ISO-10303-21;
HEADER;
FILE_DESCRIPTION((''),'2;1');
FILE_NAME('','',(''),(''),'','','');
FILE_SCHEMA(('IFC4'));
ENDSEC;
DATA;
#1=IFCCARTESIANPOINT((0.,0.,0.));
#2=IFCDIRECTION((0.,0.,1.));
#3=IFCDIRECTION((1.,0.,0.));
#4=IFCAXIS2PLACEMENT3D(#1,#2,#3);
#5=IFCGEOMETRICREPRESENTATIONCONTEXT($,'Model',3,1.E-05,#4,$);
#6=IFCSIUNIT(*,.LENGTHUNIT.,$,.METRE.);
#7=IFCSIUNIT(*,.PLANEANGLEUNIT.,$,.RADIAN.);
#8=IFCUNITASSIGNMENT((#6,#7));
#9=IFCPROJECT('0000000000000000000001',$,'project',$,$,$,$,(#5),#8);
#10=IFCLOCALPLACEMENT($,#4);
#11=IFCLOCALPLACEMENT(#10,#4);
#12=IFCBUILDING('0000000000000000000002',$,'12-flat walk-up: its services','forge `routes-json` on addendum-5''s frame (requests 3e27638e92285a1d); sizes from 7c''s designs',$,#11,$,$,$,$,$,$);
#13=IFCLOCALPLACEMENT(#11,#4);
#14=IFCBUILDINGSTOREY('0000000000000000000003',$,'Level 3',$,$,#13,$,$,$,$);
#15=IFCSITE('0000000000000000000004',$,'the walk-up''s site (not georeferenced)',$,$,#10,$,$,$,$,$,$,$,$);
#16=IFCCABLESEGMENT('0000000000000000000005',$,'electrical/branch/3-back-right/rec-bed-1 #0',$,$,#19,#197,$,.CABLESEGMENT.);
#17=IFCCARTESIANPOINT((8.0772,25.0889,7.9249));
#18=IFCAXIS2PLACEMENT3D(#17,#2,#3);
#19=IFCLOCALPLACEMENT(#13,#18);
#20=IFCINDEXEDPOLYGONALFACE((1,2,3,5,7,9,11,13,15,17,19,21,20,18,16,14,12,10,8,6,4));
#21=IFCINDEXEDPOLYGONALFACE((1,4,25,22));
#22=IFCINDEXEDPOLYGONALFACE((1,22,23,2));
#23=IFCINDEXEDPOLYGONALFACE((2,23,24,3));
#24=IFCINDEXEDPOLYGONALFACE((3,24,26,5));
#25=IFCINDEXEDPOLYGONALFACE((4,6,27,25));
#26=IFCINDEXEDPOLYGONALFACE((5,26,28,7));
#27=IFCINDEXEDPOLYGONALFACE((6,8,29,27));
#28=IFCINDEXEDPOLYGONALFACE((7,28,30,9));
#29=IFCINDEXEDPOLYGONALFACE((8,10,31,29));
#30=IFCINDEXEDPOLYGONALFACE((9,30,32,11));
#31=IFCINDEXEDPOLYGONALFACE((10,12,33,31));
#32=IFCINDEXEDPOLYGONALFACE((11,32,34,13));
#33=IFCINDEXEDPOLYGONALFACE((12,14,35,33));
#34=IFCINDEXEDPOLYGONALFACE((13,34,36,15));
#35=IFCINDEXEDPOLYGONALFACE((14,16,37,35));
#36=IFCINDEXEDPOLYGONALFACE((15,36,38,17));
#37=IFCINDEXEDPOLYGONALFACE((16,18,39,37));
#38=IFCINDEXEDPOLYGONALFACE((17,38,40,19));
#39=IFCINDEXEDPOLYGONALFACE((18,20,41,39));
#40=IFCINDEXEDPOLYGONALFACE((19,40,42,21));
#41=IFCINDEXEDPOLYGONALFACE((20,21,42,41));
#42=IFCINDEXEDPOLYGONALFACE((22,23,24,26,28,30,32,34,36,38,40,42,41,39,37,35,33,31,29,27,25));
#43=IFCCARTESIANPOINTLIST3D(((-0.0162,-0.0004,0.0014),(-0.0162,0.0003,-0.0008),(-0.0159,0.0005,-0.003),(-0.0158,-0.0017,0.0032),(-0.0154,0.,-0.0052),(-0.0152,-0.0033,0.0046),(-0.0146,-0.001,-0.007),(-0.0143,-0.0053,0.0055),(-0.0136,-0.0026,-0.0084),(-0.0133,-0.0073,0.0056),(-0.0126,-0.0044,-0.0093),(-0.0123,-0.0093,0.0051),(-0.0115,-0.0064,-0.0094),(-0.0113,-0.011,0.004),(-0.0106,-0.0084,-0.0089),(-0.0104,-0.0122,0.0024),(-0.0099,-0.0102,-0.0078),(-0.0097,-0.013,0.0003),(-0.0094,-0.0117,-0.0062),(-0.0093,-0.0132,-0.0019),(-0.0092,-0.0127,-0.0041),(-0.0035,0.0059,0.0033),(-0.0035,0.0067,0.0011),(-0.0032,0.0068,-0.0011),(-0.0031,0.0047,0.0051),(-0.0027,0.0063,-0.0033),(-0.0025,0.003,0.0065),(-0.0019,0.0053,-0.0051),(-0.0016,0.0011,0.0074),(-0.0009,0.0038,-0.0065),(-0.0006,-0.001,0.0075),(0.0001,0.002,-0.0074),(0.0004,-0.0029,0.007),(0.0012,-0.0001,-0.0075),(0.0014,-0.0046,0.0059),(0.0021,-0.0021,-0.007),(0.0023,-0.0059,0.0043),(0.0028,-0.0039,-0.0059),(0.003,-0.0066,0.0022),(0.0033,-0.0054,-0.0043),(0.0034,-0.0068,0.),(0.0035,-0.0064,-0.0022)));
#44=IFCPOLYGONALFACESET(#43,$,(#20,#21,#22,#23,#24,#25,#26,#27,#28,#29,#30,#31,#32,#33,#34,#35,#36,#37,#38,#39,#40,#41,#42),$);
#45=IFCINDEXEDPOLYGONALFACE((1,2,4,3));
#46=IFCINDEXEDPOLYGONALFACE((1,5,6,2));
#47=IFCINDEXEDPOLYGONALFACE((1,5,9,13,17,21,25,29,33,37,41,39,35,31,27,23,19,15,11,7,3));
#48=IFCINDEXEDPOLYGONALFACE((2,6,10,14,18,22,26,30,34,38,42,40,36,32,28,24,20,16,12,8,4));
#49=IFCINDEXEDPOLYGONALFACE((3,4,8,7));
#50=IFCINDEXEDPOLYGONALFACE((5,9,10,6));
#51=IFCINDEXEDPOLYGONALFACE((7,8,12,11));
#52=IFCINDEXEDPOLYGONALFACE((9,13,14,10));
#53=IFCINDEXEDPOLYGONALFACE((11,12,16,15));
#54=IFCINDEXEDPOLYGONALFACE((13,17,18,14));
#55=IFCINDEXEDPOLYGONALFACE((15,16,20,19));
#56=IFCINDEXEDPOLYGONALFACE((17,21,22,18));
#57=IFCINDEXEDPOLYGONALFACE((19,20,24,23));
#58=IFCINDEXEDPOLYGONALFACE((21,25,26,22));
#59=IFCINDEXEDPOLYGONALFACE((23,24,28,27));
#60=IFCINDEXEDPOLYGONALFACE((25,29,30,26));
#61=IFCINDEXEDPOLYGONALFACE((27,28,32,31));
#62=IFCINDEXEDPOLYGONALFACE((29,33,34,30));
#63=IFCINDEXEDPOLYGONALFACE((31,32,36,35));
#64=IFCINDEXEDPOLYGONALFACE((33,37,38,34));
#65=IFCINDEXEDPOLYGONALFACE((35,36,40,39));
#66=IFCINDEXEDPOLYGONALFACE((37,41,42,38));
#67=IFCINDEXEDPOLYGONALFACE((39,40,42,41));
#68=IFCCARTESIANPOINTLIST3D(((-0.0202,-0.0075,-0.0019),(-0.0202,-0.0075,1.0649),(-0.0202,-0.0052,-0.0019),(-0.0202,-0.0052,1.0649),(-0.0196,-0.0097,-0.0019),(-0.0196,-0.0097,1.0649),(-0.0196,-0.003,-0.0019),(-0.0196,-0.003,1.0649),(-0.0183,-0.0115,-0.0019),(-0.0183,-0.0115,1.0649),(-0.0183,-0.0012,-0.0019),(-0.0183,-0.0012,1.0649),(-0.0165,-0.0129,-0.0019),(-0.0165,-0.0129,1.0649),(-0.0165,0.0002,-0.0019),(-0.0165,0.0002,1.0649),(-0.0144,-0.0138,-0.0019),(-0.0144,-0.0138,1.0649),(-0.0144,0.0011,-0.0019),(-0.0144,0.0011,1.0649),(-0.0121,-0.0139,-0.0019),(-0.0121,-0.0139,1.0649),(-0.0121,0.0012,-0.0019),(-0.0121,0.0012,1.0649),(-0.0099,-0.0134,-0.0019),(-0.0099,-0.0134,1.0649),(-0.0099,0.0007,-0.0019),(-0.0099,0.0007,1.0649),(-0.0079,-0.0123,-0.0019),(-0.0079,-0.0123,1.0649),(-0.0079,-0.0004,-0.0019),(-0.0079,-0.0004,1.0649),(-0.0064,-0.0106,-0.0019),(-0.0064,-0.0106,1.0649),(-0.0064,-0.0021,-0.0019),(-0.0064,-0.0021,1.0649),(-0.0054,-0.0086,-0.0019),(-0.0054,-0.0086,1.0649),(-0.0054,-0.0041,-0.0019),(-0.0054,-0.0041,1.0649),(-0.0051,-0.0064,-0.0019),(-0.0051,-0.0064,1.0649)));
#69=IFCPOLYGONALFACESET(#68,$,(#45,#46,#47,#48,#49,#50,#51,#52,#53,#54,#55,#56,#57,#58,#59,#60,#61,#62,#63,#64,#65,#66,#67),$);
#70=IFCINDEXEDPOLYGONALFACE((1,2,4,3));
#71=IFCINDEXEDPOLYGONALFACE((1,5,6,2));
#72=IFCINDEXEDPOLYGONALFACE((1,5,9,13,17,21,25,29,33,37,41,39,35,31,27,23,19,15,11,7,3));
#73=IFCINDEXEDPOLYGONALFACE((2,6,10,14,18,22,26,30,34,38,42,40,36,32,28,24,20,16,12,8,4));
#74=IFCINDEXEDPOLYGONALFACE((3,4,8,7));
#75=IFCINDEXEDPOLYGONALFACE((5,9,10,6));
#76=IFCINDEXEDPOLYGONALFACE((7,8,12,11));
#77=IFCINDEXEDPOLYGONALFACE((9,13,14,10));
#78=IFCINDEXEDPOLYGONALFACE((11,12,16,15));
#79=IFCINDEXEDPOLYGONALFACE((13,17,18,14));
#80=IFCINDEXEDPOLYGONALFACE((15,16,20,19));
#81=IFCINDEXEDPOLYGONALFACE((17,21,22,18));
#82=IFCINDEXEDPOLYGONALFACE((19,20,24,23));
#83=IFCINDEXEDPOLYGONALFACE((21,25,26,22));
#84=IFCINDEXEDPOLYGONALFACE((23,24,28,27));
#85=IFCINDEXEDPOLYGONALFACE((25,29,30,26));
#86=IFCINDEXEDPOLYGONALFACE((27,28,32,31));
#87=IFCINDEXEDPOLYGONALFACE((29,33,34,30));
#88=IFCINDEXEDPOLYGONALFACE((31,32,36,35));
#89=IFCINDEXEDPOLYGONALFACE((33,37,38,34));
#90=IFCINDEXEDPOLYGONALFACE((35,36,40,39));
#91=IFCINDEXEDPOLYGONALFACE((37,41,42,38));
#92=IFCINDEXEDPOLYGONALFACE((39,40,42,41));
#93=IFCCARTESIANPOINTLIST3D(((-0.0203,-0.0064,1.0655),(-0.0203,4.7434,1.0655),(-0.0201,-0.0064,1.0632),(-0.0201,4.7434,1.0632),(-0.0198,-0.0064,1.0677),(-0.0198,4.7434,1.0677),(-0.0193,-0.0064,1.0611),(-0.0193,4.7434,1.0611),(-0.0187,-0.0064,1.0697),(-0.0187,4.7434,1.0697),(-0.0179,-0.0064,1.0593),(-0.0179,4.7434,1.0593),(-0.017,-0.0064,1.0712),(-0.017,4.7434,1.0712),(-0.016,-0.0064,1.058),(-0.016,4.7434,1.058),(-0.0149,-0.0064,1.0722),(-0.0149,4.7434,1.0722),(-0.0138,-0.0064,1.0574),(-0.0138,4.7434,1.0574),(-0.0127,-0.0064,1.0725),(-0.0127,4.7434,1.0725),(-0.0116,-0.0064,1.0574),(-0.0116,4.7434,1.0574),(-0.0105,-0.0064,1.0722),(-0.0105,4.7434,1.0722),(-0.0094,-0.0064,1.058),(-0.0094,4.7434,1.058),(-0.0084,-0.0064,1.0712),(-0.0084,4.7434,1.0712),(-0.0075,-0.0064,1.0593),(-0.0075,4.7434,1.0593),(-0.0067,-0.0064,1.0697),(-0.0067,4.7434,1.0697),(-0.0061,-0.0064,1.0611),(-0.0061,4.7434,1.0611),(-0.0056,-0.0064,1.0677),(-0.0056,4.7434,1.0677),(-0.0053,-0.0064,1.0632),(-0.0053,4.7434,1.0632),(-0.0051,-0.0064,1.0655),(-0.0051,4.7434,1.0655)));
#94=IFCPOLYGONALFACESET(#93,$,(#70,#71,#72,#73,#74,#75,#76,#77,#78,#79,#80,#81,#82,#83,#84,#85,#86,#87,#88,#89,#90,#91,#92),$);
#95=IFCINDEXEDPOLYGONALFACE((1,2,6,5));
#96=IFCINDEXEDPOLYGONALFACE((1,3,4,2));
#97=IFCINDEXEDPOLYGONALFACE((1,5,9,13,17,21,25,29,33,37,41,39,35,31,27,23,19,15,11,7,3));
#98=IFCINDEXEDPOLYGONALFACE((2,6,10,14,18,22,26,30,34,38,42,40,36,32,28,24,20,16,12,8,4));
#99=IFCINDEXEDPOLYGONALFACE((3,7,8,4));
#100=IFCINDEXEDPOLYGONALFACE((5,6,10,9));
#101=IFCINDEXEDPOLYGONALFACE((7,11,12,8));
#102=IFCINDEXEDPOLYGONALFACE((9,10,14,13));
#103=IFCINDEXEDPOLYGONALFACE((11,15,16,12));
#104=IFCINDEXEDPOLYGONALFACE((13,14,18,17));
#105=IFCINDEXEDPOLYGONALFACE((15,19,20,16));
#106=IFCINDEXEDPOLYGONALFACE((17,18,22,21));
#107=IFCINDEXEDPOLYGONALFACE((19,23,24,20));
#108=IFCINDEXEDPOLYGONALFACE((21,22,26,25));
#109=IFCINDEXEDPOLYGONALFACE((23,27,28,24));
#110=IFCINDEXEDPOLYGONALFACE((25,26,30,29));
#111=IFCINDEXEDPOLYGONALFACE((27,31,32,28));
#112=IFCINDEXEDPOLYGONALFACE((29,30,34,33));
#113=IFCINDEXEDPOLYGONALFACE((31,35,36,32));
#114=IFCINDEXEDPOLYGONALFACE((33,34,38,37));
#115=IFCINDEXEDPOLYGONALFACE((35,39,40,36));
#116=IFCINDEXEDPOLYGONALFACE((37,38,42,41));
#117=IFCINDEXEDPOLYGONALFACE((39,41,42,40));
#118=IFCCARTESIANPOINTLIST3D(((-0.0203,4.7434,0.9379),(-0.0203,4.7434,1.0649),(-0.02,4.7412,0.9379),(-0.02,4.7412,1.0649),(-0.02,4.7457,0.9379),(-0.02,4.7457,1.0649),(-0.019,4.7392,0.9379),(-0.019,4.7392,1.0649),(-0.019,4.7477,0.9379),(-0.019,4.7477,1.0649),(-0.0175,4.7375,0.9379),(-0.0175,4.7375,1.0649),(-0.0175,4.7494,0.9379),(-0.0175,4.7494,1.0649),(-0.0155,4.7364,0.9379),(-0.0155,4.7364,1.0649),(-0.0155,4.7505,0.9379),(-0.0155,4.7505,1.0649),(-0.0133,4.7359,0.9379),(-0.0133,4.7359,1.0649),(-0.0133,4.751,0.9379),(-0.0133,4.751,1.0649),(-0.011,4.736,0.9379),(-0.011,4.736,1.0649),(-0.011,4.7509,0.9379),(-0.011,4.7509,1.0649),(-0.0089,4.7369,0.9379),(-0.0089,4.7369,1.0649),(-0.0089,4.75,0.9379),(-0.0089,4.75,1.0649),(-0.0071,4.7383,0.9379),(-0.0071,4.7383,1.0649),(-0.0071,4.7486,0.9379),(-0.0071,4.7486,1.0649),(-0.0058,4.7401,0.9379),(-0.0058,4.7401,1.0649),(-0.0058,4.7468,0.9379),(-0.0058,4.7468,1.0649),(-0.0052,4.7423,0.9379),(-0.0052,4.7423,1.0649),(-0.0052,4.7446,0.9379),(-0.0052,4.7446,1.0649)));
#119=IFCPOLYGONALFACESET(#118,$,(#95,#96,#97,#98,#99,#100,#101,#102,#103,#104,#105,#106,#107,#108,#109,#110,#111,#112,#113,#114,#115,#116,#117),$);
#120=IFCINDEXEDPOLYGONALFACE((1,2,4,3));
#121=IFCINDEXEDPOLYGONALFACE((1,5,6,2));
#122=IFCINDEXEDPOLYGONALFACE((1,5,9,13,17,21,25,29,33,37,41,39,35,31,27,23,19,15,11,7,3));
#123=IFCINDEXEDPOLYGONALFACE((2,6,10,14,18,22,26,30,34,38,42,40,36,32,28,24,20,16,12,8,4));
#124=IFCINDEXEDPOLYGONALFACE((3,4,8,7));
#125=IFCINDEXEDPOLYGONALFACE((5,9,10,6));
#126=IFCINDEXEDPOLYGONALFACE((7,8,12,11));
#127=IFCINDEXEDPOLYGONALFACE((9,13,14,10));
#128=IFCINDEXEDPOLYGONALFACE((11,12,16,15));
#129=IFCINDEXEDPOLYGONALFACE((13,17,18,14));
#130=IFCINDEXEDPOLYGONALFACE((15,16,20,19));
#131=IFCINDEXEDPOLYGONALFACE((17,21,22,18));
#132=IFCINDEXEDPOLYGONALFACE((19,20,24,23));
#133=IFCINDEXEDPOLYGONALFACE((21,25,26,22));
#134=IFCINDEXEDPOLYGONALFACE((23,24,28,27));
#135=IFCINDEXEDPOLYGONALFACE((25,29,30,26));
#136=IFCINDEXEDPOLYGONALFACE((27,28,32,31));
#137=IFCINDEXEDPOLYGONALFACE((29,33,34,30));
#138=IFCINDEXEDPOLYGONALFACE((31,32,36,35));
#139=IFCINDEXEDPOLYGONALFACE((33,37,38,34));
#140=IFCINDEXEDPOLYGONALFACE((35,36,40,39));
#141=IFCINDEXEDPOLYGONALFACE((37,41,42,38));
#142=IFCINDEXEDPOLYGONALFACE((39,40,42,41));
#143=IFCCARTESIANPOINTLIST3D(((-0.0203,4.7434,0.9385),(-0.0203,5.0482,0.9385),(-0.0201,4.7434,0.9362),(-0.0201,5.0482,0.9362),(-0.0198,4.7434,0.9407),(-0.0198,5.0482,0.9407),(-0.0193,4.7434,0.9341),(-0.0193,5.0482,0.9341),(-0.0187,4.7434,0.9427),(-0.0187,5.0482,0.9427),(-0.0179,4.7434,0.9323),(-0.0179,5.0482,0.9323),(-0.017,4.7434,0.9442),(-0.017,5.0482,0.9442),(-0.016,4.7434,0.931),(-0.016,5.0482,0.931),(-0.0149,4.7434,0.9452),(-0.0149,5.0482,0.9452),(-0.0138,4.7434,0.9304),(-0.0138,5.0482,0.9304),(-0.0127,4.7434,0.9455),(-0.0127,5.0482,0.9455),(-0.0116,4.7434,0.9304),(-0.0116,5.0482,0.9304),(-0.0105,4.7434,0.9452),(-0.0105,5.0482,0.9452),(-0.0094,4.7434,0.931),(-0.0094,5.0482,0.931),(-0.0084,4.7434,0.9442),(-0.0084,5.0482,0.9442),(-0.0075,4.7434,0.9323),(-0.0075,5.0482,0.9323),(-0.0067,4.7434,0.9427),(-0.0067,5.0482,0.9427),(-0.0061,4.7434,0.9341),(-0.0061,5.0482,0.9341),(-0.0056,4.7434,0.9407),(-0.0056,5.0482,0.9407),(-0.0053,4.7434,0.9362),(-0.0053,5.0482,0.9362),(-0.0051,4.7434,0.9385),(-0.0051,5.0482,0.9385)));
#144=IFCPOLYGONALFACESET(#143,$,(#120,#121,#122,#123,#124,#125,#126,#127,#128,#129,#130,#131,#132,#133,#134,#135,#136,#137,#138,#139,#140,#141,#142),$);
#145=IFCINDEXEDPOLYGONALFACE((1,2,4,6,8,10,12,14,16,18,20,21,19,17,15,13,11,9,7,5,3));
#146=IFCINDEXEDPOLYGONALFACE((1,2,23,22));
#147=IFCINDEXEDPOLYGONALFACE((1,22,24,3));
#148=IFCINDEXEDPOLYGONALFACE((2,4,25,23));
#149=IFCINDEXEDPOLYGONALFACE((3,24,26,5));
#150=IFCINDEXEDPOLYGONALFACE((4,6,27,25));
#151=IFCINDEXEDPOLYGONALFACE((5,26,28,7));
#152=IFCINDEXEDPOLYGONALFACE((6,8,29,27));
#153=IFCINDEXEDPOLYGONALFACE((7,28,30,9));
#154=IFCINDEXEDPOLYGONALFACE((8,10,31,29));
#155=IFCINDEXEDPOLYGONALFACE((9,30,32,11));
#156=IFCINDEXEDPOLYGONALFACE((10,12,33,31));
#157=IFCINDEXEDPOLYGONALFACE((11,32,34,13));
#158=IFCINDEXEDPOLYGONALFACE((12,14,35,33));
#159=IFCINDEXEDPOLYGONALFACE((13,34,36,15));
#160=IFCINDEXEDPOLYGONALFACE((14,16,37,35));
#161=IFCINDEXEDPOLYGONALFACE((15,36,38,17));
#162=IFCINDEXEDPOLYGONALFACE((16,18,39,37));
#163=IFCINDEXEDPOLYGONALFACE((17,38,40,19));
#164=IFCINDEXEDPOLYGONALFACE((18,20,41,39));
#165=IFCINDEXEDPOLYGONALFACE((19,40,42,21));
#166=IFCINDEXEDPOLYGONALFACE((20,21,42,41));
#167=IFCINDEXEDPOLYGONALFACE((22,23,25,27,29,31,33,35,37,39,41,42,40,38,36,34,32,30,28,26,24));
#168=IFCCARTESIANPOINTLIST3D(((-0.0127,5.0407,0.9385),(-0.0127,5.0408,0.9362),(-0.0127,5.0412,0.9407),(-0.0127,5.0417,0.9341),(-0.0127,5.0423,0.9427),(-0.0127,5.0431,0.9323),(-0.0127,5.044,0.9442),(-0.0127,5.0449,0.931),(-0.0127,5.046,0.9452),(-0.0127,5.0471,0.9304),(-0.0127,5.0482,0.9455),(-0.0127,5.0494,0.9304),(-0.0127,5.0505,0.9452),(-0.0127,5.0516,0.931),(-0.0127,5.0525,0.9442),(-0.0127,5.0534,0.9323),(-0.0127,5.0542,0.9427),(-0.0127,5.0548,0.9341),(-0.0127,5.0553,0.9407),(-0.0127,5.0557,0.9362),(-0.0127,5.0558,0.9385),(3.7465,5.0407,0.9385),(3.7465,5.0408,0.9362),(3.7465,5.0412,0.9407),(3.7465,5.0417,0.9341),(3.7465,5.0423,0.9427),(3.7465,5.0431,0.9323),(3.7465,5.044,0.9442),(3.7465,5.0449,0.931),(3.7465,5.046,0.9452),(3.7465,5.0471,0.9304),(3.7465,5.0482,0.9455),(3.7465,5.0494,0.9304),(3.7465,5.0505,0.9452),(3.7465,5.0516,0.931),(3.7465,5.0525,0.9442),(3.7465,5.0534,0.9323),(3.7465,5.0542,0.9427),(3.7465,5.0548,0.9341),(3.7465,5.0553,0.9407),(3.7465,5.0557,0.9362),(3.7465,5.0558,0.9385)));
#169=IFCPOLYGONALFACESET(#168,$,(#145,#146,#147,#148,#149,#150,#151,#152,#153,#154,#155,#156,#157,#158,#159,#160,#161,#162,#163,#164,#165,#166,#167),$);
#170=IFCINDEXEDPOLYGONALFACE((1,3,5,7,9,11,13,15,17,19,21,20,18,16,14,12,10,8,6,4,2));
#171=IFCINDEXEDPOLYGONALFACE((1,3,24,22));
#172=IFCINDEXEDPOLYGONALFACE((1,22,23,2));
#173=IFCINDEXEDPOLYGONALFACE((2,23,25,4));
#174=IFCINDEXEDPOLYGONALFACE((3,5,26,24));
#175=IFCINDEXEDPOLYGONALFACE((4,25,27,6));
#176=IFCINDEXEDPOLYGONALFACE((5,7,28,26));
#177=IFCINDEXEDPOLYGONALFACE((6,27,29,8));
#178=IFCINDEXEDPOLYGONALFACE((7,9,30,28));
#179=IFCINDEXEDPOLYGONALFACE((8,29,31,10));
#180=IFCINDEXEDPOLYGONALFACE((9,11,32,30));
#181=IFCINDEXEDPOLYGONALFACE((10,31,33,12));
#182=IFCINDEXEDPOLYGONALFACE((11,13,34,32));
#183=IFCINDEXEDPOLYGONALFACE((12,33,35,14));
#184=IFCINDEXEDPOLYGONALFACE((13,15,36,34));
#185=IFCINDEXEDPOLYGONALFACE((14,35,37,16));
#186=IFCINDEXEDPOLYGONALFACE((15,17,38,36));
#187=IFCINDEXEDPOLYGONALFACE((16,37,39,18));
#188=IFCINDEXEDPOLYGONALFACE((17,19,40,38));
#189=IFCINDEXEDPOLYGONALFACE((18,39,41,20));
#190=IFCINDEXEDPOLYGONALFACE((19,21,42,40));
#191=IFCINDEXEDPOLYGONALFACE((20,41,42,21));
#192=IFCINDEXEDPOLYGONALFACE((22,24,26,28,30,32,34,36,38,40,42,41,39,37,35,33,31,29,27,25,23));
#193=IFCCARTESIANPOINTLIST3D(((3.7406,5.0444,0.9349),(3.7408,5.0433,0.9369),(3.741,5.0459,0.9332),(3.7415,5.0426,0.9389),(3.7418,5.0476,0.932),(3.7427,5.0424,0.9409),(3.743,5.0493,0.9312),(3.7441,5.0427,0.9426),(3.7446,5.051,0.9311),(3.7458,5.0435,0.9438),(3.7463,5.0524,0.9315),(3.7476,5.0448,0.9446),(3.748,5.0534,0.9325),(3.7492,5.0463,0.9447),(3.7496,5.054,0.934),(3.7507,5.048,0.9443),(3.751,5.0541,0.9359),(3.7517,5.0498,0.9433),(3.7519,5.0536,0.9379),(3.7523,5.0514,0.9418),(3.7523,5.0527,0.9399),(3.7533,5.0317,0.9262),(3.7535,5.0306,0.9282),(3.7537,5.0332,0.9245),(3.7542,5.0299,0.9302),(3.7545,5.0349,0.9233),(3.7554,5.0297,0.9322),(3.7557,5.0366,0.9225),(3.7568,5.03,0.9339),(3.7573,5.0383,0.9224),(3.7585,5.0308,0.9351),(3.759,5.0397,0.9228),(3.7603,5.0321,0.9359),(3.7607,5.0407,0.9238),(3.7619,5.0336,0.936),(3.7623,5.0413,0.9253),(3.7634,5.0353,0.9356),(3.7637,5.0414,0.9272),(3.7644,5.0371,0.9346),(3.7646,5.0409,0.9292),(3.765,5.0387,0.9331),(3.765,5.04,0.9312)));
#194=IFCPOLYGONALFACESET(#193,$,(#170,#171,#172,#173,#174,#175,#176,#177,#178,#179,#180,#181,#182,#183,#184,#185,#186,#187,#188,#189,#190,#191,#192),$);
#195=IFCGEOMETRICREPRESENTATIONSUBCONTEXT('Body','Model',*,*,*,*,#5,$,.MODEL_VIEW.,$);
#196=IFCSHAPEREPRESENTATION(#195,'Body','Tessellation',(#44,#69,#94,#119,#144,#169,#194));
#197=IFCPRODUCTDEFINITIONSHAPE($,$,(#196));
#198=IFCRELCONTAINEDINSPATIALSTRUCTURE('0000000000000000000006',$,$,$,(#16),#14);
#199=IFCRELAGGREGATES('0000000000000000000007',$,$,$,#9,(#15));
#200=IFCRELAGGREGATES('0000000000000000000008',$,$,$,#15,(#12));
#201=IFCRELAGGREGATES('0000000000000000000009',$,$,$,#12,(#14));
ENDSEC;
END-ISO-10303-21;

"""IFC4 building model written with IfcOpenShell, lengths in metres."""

from ifc_helpers import new_model, entity, si_unit, frame, origin_with_axes, place, context, subcontext, project, spatial, element, save


model = new_model("IFC4")

# Units and contexts
model_context = context("Model", 3, precision=1e-05, world=origin_with_axes())
body_context = subcontext(model_context, "Body", "Model", "MODEL_VIEW")
ifc_project = project(units=[si_unit("LENGTHUNIT", "METRE"), si_unit("PLANEANGLEUNIT", "RADIAN")], contexts=[model_context])

# Site, building, storey
site_placement = place(None, origin_with_axes())
site = spatial("IfcSite", under=ifc_project, at=site_placement, Name="the walk-up's site (not georeferenced)")
building_placement = place(site_placement, origin_with_axes())
building = spatial("IfcBuilding", under=site, at=building_placement, Name="12-flat walk-up: its services", Description="forge `routes-json` on addendum-5's frame (requests 3e27638e92285a1d); sizes from 7c's designs")
storey_placement = place(building_placement, origin_with_axes())
storey = spatial("IfcBuildingStorey", under=building, at=storey_placement, Name="Level 3")

# Cable segment
cable_segment_1_placement = place(storey_placement, frame((8.0772, 25.0889, 7.9249), z_axis=(0.0, 0.0, 1.0), x_axis=(1.0, 0.0, 0.0)))
element("IfcCableSegment", 1, at=cable_segment_1_placement, inside=storey, Name="electrical/branch/3-back-right/rec-bed-1 #0", PredefinedType="CABLESEGMENT", context=body_context, shape_type="AdvancedSweptSolid", body=[
    entity("IfcSweptDiskSolid", entity("IfcPolyline", [entity("IfcCartesianPoint", [0.0, 0.0, 0.0]), entity("IfcCartesianPoint", [-0.0127, -0.0064, -0.0019])]), 0.0076),
    entity("IfcSweptDiskSolid", entity("IfcPolyline", [entity("IfcCartesianPoint", [-0.0127, -0.0064, -0.0019]), entity("IfcCartesianPoint", [-0.0127, -0.0064, 1.0649])]), 0.0076),
    entity("IfcSweptDiskSolid", entity("IfcPolyline", [entity("IfcCartesianPoint", [-0.0127, -0.0064, 1.0649]), entity("IfcCartesianPoint", [-0.0127, 4.7434, 1.0649])]), 0.0076),
    entity("IfcSweptDiskSolid", entity("IfcPolyline", [entity("IfcCartesianPoint", [-0.0127, 4.7434, 1.0649]), entity("IfcCartesianPoint", [-0.0127, 4.7434, 0.9379])]), 0.0076),
    entity("IfcSweptDiskSolid", entity("IfcPolyline", [entity("IfcCartesianPoint", [-0.0127, 4.7434, 0.9379]), entity("IfcCartesianPoint", [-0.0127, 5.0482, 0.9379])]), 0.0076),
    entity("IfcSweptDiskSolid", entity("IfcPolyline", [entity("IfcCartesianPoint", [-0.0127, 5.0482, 0.9379]), entity("IfcCartesianPoint", [3.7465, 5.0482, 0.9379])]), 0.0076),
    entity("IfcSweptDiskSolid", entity("IfcPolyline", [entity("IfcCartesianPoint", [3.7465, 5.0482, 0.9379]), entity("IfcCartesianPoint", [3.7592, 5.0356, 0.9292])]), 0.0076),
])

save(model, "model.ifc")
